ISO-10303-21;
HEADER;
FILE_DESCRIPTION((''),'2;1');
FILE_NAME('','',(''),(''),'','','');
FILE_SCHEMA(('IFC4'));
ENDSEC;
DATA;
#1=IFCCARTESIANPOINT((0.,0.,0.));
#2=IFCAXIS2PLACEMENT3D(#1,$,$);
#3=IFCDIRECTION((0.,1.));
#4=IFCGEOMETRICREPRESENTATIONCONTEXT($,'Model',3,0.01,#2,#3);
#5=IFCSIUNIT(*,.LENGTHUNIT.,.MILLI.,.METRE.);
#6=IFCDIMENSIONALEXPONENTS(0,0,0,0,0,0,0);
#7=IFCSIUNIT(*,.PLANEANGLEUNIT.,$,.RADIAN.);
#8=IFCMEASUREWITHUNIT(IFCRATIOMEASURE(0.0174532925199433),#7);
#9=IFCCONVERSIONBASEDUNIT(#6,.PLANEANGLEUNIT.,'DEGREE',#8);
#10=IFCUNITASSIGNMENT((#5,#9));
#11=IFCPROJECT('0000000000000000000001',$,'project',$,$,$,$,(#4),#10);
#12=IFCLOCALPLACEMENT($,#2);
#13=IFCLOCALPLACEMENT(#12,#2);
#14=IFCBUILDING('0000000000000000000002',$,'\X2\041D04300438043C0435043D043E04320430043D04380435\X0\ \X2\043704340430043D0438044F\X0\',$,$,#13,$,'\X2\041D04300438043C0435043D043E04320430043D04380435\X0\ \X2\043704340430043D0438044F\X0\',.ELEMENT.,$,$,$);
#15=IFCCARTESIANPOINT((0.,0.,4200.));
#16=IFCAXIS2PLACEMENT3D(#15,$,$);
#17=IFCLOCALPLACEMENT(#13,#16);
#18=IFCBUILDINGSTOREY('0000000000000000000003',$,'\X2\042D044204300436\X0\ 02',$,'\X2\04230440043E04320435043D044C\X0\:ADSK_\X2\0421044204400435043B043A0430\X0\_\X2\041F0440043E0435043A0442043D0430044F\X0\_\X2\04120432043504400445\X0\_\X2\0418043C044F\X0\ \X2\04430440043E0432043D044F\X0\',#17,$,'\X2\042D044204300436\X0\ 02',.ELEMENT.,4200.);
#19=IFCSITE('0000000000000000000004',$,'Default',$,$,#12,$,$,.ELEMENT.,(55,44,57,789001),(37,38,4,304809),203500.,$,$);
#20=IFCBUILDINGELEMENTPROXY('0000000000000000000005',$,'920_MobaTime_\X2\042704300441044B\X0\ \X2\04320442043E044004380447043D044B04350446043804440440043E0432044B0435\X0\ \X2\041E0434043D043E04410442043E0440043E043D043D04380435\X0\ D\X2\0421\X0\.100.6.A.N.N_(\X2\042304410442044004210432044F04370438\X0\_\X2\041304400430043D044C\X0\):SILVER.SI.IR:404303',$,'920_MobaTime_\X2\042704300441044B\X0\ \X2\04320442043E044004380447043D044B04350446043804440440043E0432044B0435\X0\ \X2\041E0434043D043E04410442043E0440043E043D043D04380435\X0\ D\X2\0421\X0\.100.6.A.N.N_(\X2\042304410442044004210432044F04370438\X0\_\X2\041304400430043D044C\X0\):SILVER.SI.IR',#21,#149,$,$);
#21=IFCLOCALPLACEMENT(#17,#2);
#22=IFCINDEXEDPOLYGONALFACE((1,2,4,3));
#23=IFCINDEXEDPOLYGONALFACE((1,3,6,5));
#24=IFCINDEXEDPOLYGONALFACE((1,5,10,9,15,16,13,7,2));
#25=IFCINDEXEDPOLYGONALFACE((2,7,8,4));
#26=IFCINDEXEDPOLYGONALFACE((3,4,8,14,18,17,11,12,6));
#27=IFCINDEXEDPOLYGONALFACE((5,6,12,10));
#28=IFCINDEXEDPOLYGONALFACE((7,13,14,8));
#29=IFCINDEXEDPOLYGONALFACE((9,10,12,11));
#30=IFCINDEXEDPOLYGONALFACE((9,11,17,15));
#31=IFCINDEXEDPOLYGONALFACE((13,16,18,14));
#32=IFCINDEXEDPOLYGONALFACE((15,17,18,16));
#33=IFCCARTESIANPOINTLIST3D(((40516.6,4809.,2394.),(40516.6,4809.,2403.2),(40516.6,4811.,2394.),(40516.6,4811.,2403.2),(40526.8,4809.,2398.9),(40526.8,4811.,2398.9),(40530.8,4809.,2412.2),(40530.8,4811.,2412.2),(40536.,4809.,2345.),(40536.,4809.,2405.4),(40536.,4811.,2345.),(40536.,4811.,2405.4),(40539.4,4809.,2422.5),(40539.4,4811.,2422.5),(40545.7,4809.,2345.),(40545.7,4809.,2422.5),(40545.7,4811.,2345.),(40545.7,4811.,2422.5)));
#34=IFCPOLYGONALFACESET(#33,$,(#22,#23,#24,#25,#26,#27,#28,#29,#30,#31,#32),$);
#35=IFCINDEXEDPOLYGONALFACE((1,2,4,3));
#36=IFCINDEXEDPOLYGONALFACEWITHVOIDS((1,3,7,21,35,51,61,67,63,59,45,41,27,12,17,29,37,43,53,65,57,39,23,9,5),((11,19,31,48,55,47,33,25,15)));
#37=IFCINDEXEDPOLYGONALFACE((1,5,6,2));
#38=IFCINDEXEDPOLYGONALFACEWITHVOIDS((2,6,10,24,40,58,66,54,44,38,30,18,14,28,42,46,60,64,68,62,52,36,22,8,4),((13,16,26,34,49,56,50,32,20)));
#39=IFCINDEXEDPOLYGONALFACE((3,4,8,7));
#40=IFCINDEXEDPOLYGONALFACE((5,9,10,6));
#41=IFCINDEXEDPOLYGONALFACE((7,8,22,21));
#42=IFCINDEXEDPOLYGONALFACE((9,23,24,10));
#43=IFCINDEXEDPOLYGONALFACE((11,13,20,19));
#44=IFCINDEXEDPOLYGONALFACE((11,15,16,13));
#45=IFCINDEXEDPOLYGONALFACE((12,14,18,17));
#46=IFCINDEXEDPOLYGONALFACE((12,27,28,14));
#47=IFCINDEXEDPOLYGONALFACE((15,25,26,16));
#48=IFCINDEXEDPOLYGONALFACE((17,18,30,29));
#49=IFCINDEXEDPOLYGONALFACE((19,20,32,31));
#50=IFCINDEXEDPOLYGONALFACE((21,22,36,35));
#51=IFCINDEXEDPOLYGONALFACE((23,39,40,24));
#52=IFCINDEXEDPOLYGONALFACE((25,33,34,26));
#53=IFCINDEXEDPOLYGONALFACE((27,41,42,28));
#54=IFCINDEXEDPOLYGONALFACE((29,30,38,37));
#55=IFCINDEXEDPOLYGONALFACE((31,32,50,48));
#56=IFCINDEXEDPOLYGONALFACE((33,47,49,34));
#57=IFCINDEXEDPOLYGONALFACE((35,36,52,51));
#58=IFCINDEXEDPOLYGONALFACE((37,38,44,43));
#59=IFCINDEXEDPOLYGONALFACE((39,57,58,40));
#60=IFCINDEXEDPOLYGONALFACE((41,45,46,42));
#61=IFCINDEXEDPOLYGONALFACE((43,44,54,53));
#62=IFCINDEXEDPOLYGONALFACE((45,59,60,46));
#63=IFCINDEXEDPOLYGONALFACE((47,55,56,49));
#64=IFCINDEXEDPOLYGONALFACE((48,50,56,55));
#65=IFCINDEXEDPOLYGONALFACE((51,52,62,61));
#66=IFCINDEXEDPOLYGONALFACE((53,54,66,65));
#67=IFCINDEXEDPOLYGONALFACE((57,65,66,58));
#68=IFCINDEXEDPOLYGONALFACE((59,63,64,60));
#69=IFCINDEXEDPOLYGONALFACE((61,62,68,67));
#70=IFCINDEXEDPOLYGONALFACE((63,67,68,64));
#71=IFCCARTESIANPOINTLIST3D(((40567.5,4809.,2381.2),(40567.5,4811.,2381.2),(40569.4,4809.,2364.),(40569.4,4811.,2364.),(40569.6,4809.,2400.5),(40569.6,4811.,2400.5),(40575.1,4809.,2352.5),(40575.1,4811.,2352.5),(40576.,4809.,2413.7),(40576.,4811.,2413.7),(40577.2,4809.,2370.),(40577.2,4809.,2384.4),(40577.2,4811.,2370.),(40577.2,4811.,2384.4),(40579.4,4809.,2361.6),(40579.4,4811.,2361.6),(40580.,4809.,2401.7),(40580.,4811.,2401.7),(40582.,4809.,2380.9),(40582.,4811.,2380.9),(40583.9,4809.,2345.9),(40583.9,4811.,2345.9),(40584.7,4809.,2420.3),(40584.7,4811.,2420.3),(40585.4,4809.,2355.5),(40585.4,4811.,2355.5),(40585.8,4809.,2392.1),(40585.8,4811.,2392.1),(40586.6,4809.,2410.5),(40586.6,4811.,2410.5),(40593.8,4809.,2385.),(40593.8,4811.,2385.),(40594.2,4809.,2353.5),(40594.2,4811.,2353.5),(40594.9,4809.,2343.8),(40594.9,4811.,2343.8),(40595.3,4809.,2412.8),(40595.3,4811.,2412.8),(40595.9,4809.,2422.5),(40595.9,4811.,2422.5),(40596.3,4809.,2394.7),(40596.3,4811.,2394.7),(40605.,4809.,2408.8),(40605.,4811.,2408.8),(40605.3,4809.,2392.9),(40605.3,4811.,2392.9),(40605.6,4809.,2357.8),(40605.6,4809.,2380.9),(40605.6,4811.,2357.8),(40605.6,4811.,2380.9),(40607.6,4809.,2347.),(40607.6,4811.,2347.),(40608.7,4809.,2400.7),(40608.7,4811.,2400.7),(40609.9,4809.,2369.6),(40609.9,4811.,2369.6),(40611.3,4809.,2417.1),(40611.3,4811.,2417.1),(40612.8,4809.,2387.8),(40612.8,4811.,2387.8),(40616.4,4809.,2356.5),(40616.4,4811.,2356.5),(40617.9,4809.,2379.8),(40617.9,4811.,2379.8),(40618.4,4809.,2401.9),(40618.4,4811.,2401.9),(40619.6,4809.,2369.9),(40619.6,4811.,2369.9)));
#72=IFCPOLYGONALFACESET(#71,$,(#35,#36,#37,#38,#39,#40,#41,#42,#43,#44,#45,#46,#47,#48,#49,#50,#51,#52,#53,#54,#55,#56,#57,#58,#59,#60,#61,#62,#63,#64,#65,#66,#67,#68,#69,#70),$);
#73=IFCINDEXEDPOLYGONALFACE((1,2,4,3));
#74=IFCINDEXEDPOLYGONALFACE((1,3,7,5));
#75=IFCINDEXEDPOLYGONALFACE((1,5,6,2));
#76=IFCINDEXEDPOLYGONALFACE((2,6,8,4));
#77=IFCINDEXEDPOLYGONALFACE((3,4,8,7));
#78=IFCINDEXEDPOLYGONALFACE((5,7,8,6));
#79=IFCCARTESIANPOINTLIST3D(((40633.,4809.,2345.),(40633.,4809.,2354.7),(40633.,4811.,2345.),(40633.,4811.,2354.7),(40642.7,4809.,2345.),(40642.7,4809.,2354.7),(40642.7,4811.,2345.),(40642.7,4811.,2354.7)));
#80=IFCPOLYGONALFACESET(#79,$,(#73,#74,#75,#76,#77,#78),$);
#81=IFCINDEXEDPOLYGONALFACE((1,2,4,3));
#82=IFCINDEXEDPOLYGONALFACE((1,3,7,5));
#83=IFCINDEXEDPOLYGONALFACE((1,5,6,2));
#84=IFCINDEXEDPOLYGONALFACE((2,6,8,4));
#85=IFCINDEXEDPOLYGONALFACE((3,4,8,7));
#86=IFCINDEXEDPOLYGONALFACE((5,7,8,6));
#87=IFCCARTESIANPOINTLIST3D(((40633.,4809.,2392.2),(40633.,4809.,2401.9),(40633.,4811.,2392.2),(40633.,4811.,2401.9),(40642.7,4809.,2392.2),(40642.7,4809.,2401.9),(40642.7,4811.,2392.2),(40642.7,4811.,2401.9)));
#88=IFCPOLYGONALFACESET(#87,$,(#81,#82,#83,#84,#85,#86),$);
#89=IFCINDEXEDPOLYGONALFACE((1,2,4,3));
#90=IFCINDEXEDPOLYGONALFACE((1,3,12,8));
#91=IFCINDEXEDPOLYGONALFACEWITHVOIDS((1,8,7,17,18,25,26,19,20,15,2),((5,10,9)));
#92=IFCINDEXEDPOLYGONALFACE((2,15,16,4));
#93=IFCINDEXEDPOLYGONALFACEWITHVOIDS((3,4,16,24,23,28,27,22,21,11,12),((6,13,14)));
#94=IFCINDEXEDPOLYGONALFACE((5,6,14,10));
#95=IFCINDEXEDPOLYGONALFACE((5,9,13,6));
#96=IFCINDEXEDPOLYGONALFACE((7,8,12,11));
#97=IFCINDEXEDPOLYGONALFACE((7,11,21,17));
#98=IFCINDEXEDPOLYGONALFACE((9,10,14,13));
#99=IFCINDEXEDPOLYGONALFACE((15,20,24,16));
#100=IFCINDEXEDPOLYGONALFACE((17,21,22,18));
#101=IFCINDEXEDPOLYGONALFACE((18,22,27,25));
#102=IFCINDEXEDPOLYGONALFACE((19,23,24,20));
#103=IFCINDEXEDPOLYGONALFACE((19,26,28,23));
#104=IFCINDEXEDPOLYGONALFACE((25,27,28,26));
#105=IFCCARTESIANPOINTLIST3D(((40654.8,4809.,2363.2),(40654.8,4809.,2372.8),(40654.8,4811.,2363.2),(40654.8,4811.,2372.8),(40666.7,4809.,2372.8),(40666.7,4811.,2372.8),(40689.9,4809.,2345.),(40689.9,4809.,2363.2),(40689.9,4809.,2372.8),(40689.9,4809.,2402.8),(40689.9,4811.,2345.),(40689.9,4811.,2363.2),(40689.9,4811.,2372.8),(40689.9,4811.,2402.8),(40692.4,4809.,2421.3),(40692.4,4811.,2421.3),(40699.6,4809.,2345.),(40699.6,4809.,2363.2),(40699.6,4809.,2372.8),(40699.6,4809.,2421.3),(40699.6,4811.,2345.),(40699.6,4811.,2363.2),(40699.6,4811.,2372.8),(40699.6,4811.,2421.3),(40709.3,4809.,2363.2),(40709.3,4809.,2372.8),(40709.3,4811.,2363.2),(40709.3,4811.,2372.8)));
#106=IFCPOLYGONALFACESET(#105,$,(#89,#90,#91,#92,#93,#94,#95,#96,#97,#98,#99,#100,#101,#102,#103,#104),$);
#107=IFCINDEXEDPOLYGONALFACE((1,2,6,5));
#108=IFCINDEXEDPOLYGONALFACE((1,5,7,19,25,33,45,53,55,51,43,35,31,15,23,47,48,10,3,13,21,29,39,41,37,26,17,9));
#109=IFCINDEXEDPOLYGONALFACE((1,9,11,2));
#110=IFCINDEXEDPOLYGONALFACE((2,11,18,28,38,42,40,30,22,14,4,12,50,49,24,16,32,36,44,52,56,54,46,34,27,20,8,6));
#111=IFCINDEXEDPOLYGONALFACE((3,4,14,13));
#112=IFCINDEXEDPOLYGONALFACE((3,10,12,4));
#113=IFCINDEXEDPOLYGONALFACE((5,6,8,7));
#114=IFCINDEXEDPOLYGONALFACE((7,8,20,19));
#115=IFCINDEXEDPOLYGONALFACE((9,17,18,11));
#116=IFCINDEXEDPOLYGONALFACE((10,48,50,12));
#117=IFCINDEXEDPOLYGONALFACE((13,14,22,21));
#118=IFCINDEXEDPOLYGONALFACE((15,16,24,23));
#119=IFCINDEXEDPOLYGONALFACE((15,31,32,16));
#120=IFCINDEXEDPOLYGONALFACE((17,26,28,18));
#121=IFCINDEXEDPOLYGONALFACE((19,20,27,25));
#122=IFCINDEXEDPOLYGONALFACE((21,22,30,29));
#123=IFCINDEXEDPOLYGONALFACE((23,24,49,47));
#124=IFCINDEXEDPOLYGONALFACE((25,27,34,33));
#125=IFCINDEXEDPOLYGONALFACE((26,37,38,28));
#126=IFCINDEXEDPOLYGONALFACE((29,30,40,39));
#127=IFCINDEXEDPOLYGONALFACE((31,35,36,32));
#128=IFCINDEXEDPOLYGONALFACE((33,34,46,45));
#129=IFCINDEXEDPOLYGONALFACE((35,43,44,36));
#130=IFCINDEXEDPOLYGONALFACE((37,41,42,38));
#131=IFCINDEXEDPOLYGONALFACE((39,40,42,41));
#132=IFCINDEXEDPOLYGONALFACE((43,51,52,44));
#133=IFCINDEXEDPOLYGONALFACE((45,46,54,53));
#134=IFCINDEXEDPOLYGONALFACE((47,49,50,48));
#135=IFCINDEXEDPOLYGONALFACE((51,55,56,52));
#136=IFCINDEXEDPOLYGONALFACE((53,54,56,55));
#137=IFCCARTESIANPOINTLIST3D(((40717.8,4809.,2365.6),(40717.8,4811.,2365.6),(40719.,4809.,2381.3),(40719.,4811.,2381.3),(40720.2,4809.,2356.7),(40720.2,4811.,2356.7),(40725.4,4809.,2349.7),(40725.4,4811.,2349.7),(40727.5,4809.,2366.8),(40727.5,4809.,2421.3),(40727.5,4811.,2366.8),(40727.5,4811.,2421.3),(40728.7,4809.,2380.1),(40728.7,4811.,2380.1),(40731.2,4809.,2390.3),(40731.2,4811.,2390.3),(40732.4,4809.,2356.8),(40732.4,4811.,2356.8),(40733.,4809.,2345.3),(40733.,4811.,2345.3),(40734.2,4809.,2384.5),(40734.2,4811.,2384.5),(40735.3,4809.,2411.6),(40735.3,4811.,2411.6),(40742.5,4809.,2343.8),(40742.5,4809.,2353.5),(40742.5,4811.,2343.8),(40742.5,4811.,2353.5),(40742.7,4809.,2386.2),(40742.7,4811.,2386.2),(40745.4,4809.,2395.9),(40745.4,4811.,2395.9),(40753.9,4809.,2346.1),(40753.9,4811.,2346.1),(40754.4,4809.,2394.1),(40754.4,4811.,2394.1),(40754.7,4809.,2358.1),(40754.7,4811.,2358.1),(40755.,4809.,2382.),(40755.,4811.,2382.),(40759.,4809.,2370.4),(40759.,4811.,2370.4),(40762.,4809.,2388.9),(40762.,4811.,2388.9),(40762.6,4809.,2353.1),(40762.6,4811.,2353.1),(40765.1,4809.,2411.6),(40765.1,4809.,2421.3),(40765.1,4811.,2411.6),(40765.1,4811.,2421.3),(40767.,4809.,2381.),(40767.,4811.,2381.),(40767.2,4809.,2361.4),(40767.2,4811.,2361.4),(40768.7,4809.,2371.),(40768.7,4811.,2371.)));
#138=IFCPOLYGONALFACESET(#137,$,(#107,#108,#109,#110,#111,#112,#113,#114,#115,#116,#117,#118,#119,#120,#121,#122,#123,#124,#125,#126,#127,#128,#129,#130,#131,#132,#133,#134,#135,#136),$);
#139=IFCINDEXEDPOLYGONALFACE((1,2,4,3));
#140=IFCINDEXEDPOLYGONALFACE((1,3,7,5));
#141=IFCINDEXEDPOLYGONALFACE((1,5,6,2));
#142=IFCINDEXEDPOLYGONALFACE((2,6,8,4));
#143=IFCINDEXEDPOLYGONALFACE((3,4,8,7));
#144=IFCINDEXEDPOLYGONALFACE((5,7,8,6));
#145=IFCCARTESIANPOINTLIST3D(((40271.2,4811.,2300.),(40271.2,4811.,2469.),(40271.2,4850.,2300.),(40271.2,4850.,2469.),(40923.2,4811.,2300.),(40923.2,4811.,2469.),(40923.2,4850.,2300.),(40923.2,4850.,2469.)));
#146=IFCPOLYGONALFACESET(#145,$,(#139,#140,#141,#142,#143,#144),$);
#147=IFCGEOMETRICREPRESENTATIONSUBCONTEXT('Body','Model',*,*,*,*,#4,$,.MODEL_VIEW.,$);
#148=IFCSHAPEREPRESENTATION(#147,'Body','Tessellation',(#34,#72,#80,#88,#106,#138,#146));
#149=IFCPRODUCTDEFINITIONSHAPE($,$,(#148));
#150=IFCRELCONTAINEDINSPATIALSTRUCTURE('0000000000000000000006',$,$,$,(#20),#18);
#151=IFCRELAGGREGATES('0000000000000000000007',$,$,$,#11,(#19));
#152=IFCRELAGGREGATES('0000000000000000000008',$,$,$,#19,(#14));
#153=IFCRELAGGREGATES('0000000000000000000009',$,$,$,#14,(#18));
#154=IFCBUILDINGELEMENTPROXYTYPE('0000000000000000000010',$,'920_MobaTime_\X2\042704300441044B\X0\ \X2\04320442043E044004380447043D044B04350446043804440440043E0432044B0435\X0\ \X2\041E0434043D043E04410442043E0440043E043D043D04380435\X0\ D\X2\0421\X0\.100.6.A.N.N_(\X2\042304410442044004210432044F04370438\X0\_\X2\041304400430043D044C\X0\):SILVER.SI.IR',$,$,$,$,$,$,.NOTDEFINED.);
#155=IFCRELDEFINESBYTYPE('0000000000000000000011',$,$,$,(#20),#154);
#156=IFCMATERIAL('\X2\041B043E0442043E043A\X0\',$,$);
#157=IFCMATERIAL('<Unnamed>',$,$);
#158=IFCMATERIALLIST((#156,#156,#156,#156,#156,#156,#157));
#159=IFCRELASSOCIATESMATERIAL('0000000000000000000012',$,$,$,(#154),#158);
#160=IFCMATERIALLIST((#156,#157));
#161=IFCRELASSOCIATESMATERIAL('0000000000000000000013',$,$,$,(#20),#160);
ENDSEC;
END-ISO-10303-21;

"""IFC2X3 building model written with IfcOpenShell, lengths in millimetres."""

from ifc_helpers import new_model, entity, si_unit, converted_unit, direction, frame, origin, origin_2d_with_axis, place, context, subcontext, project, spatial, polyline, rectangle, outline, extrude, source, transform, mapped, material, material_list, type_object, type_shapes, element, save


model = new_model("IFC2X3")

# Units and contexts
model_context = context("Model", 3, precision=0.01, world=origin(), true_north=direction((0.0, 1.0)))
body_context = subcontext(model_context, "Body", "Model", "MODEL_VIEW")
ifc_project = project(units=[si_unit("LENGTHUNIT", "METRE", prefix="MILLI"), converted_unit("PLANEANGLEUNIT", "DEGREE", entity("IfcRatioMeasure", 0.0174532925199433), si_unit("PLANEANGLEUNIT", "RADIAN"), dimensions=[0, 0, 0, 0, 0, 0, 0])], contexts=[model_context])

# Site, building, storey
site_placement = place(None, frame((0.0, 0.0, 0.0)))
site = spatial("IfcSite", under=ifc_project, at=site_placement, Name="Default", CompositionType="ELEMENT", RefLatitude=(55, 44, 57, 789001), RefLongitude=(37, 38, 4, 304809), RefElevation=203500.0)
building_placement = place(site_placement, origin())
building = spatial("IfcBuilding", under=site, at=building_placement, Name="Наименование здания", LongName="Наименование здания", CompositionType="ELEMENT")
storey_placement = place(building_placement, frame((0.0, 0.0, 4200.0)))
storey = spatial("IfcBuildingStorey", under=building, at=storey_placement, Name="Этаж 02", ObjectType="Уровень:ADSK_Стрелка_Проектная_Вверх_Имя уровня", LongName="Этаж 02", CompositionType="ELEMENT", Elevation=4200.0)

# Building element proxy
ifc_material_1 = material(Name="Лоток")
ifc_material_2 = material(Name="<Unnamed>")
ifc_material_list_1 = material_list([ifc_material_1, ifc_material_1, ifc_material_1, ifc_material_1, ifc_material_1, ifc_material_1, ifc_material_2])
building_element_proxy_type_1 = type_object("IfcBuildingElementProxyType", Name="920_MobaTime_Часы вторичныецифровые Односторонние DС.100.6.A.N.N_(УстрСвязи_Грань):SILVER.SI.IR", PredefinedType="NOTDEFINED", material=ifc_material_list_1)
shared_shape_1 = source(origin(), body_context, "Body", "SweptSolid", [
    extrude(outline(polyline([(-49.3, -13.1), (28.2, -13.1), (28.2, -6.8), (17.9, 1.8), (8.9, 16.0), (-0.3, 16.0), (4.6, 5.8), (11.1, -3.4), (-49.3, -3.4), (-49.3, -13.1)])), frame((-64.6, 9.8, 39.0), z_axis=(0.0, 0.0, 1.0), x_axis=(0.0, 1.0, 0.0)), (0.0, 0.0, 1.0), 2.0),
    extrude(outline(polyline([(2.2, -27.6), (19.0, -27.6), (30.5, -16.1), (33.3, -4.9), (31.0, 5.8), (21.8, 17.2), (5.2, 27.3), (-11.1, 33.0), (-24.0, 32.7), (-33.6, 27.6), (-40.3, 18.6), (-42.8, 5.7), (-38.0, -6.3), (-27.2, -15.0), (-17.5, -17.7), (-8.2, -16.4), (-0.3, -11.9), (5.1, -4.5), (7.3, 6.2), (4.0, 17.2), (18.5, 7.3), (23.6, -2.4), (22.0, -11.4), (14.2, -18.4), (5.3, -18.3), (2.2, -27.6)]), holes=[polyline([(-9.0, 23.3), (-1.3, 14.4), (-2.6, 2.0), (-11.4, -7.0), (-23.4, -6.1), (-32.2, 2.9), (-31.2, 15.1), (-25.6, 22.1), (-17.5, 24.9), (-9.0, 23.3)])]), frame((-2.7, 3.6, 39.0), z_axis=(0.0, 0.0, 1.0), x_axis=(-0.427649, 0.903945, 0.0)), (0.0, 0.0, 1.0), 2.0),
    extrude(rectangle(XDim=9.7, YDim=9.7, at=origin_2d_with_axis()), frame((40.6, -34.7, 39.0)), (0.0, 0.0, 1.0), 2.0),
    extrude(rectangle(XDim=9.7, YDim=9.7, at=origin_2d_with_axis()), frame((40.6, 12.6, 39.0)), (0.0, 0.0, 1.0), 2.0),
    extrude(outline(polyline([(-0.9, -28.1), (8.8, -28.1), (8.8, -9.9), (18.5, -9.9), (18.5, -0.2), (8.8, -0.2), (8.8, 48.3), (1.5, 48.3), (-36.0, -0.2), (-36.0, -9.9), (-0.9, -9.9), (-0.9, -28.1)]), holes=[polyline([(-0.9, -0.2), (-24.1, -0.2), (-0.9, 29.7), (-0.9, -0.2)])]), frame((93.6, -11.4, 39.0)), (0.0, 0.0, 1.0), 2.0),
    extrude(outline(polyline([(3.3, -28.3), (12.5, -28.3), (20.5, -25.0), (26.8, -18.8), (30.7, -10.0), (31.4, 1.6), (26.9, 11.8), (20.1, 18.4), (11.1, 22.3), (1.0, 23.3), (-7.9, 20.4), (-14.9, 14.5), (-18.9, 6.2), (-17.1, -9.0), (-36.7, 0.5), (-29.1, 29.3), (-38.5, 31.7), (-48.1, -4.6), (-11.6, -23.0), (-8.0, -14.0), (-10.8, -7.6), (-10.2, 1.1), (-3.0, 11.8), (9.2, 12.8), (20.0, 5.4), (21.3, -7.5), (15.5, -16.4), (4.6, -18.6), (3.3, -28.3)])), frame((147.1, -8.5, 39.0), z_axis=(0.0, 0.0, 1.0), x_axis=(0.256974, -0.966418, 0.0)), (0.0, 0.0, 1.0), 2.0),
    extrude(rectangle(XDim=652.0, YDim=169.0, at=origin_2d_with_axis()), frame((0.0, 0.0, 0.0), z_axis=(0.0, 0.0, 1.0), x_axis=(-1.0, 0.0, 0.0)), (0.0, 0.0, 1.0), 39.0),
])
type_shapes(building_element_proxy_type_1, [shared_shape_1])
ifc_material_list_2 = material_list([ifc_material_1, ifc_material_2])
proxy_1_placement = place(storey_placement, frame((40597.2, 4850.0, 2384.5), z_axis=(0.0, -1.0, 0.0), x_axis=(1.0, 0.0, 0.0)))
element("IfcBuildingElementProxy", 1, at=proxy_1_placement, inside=storey, type_object=building_element_proxy_type_1, material=ifc_material_list_2, Name="920_MobaTime_Часы вторичныецифровые Односторонние DС.100.6.A.N.N_(УстрСвязи_Грань):SILVER.SI.IR:404303", ObjectType="920_MobaTime_Часы вторичныецифровые Односторонние DС.100.6.A.N.N_(УстрСвязи_Грань):SILVER.SI.IR", context=body_context, shape_type="MappedRepresentation", body=[
    mapped(shared_shape_1, transform((0.0, 0.0, 0.0), scale=1.0)),
])

save(model, "model.ifc")
